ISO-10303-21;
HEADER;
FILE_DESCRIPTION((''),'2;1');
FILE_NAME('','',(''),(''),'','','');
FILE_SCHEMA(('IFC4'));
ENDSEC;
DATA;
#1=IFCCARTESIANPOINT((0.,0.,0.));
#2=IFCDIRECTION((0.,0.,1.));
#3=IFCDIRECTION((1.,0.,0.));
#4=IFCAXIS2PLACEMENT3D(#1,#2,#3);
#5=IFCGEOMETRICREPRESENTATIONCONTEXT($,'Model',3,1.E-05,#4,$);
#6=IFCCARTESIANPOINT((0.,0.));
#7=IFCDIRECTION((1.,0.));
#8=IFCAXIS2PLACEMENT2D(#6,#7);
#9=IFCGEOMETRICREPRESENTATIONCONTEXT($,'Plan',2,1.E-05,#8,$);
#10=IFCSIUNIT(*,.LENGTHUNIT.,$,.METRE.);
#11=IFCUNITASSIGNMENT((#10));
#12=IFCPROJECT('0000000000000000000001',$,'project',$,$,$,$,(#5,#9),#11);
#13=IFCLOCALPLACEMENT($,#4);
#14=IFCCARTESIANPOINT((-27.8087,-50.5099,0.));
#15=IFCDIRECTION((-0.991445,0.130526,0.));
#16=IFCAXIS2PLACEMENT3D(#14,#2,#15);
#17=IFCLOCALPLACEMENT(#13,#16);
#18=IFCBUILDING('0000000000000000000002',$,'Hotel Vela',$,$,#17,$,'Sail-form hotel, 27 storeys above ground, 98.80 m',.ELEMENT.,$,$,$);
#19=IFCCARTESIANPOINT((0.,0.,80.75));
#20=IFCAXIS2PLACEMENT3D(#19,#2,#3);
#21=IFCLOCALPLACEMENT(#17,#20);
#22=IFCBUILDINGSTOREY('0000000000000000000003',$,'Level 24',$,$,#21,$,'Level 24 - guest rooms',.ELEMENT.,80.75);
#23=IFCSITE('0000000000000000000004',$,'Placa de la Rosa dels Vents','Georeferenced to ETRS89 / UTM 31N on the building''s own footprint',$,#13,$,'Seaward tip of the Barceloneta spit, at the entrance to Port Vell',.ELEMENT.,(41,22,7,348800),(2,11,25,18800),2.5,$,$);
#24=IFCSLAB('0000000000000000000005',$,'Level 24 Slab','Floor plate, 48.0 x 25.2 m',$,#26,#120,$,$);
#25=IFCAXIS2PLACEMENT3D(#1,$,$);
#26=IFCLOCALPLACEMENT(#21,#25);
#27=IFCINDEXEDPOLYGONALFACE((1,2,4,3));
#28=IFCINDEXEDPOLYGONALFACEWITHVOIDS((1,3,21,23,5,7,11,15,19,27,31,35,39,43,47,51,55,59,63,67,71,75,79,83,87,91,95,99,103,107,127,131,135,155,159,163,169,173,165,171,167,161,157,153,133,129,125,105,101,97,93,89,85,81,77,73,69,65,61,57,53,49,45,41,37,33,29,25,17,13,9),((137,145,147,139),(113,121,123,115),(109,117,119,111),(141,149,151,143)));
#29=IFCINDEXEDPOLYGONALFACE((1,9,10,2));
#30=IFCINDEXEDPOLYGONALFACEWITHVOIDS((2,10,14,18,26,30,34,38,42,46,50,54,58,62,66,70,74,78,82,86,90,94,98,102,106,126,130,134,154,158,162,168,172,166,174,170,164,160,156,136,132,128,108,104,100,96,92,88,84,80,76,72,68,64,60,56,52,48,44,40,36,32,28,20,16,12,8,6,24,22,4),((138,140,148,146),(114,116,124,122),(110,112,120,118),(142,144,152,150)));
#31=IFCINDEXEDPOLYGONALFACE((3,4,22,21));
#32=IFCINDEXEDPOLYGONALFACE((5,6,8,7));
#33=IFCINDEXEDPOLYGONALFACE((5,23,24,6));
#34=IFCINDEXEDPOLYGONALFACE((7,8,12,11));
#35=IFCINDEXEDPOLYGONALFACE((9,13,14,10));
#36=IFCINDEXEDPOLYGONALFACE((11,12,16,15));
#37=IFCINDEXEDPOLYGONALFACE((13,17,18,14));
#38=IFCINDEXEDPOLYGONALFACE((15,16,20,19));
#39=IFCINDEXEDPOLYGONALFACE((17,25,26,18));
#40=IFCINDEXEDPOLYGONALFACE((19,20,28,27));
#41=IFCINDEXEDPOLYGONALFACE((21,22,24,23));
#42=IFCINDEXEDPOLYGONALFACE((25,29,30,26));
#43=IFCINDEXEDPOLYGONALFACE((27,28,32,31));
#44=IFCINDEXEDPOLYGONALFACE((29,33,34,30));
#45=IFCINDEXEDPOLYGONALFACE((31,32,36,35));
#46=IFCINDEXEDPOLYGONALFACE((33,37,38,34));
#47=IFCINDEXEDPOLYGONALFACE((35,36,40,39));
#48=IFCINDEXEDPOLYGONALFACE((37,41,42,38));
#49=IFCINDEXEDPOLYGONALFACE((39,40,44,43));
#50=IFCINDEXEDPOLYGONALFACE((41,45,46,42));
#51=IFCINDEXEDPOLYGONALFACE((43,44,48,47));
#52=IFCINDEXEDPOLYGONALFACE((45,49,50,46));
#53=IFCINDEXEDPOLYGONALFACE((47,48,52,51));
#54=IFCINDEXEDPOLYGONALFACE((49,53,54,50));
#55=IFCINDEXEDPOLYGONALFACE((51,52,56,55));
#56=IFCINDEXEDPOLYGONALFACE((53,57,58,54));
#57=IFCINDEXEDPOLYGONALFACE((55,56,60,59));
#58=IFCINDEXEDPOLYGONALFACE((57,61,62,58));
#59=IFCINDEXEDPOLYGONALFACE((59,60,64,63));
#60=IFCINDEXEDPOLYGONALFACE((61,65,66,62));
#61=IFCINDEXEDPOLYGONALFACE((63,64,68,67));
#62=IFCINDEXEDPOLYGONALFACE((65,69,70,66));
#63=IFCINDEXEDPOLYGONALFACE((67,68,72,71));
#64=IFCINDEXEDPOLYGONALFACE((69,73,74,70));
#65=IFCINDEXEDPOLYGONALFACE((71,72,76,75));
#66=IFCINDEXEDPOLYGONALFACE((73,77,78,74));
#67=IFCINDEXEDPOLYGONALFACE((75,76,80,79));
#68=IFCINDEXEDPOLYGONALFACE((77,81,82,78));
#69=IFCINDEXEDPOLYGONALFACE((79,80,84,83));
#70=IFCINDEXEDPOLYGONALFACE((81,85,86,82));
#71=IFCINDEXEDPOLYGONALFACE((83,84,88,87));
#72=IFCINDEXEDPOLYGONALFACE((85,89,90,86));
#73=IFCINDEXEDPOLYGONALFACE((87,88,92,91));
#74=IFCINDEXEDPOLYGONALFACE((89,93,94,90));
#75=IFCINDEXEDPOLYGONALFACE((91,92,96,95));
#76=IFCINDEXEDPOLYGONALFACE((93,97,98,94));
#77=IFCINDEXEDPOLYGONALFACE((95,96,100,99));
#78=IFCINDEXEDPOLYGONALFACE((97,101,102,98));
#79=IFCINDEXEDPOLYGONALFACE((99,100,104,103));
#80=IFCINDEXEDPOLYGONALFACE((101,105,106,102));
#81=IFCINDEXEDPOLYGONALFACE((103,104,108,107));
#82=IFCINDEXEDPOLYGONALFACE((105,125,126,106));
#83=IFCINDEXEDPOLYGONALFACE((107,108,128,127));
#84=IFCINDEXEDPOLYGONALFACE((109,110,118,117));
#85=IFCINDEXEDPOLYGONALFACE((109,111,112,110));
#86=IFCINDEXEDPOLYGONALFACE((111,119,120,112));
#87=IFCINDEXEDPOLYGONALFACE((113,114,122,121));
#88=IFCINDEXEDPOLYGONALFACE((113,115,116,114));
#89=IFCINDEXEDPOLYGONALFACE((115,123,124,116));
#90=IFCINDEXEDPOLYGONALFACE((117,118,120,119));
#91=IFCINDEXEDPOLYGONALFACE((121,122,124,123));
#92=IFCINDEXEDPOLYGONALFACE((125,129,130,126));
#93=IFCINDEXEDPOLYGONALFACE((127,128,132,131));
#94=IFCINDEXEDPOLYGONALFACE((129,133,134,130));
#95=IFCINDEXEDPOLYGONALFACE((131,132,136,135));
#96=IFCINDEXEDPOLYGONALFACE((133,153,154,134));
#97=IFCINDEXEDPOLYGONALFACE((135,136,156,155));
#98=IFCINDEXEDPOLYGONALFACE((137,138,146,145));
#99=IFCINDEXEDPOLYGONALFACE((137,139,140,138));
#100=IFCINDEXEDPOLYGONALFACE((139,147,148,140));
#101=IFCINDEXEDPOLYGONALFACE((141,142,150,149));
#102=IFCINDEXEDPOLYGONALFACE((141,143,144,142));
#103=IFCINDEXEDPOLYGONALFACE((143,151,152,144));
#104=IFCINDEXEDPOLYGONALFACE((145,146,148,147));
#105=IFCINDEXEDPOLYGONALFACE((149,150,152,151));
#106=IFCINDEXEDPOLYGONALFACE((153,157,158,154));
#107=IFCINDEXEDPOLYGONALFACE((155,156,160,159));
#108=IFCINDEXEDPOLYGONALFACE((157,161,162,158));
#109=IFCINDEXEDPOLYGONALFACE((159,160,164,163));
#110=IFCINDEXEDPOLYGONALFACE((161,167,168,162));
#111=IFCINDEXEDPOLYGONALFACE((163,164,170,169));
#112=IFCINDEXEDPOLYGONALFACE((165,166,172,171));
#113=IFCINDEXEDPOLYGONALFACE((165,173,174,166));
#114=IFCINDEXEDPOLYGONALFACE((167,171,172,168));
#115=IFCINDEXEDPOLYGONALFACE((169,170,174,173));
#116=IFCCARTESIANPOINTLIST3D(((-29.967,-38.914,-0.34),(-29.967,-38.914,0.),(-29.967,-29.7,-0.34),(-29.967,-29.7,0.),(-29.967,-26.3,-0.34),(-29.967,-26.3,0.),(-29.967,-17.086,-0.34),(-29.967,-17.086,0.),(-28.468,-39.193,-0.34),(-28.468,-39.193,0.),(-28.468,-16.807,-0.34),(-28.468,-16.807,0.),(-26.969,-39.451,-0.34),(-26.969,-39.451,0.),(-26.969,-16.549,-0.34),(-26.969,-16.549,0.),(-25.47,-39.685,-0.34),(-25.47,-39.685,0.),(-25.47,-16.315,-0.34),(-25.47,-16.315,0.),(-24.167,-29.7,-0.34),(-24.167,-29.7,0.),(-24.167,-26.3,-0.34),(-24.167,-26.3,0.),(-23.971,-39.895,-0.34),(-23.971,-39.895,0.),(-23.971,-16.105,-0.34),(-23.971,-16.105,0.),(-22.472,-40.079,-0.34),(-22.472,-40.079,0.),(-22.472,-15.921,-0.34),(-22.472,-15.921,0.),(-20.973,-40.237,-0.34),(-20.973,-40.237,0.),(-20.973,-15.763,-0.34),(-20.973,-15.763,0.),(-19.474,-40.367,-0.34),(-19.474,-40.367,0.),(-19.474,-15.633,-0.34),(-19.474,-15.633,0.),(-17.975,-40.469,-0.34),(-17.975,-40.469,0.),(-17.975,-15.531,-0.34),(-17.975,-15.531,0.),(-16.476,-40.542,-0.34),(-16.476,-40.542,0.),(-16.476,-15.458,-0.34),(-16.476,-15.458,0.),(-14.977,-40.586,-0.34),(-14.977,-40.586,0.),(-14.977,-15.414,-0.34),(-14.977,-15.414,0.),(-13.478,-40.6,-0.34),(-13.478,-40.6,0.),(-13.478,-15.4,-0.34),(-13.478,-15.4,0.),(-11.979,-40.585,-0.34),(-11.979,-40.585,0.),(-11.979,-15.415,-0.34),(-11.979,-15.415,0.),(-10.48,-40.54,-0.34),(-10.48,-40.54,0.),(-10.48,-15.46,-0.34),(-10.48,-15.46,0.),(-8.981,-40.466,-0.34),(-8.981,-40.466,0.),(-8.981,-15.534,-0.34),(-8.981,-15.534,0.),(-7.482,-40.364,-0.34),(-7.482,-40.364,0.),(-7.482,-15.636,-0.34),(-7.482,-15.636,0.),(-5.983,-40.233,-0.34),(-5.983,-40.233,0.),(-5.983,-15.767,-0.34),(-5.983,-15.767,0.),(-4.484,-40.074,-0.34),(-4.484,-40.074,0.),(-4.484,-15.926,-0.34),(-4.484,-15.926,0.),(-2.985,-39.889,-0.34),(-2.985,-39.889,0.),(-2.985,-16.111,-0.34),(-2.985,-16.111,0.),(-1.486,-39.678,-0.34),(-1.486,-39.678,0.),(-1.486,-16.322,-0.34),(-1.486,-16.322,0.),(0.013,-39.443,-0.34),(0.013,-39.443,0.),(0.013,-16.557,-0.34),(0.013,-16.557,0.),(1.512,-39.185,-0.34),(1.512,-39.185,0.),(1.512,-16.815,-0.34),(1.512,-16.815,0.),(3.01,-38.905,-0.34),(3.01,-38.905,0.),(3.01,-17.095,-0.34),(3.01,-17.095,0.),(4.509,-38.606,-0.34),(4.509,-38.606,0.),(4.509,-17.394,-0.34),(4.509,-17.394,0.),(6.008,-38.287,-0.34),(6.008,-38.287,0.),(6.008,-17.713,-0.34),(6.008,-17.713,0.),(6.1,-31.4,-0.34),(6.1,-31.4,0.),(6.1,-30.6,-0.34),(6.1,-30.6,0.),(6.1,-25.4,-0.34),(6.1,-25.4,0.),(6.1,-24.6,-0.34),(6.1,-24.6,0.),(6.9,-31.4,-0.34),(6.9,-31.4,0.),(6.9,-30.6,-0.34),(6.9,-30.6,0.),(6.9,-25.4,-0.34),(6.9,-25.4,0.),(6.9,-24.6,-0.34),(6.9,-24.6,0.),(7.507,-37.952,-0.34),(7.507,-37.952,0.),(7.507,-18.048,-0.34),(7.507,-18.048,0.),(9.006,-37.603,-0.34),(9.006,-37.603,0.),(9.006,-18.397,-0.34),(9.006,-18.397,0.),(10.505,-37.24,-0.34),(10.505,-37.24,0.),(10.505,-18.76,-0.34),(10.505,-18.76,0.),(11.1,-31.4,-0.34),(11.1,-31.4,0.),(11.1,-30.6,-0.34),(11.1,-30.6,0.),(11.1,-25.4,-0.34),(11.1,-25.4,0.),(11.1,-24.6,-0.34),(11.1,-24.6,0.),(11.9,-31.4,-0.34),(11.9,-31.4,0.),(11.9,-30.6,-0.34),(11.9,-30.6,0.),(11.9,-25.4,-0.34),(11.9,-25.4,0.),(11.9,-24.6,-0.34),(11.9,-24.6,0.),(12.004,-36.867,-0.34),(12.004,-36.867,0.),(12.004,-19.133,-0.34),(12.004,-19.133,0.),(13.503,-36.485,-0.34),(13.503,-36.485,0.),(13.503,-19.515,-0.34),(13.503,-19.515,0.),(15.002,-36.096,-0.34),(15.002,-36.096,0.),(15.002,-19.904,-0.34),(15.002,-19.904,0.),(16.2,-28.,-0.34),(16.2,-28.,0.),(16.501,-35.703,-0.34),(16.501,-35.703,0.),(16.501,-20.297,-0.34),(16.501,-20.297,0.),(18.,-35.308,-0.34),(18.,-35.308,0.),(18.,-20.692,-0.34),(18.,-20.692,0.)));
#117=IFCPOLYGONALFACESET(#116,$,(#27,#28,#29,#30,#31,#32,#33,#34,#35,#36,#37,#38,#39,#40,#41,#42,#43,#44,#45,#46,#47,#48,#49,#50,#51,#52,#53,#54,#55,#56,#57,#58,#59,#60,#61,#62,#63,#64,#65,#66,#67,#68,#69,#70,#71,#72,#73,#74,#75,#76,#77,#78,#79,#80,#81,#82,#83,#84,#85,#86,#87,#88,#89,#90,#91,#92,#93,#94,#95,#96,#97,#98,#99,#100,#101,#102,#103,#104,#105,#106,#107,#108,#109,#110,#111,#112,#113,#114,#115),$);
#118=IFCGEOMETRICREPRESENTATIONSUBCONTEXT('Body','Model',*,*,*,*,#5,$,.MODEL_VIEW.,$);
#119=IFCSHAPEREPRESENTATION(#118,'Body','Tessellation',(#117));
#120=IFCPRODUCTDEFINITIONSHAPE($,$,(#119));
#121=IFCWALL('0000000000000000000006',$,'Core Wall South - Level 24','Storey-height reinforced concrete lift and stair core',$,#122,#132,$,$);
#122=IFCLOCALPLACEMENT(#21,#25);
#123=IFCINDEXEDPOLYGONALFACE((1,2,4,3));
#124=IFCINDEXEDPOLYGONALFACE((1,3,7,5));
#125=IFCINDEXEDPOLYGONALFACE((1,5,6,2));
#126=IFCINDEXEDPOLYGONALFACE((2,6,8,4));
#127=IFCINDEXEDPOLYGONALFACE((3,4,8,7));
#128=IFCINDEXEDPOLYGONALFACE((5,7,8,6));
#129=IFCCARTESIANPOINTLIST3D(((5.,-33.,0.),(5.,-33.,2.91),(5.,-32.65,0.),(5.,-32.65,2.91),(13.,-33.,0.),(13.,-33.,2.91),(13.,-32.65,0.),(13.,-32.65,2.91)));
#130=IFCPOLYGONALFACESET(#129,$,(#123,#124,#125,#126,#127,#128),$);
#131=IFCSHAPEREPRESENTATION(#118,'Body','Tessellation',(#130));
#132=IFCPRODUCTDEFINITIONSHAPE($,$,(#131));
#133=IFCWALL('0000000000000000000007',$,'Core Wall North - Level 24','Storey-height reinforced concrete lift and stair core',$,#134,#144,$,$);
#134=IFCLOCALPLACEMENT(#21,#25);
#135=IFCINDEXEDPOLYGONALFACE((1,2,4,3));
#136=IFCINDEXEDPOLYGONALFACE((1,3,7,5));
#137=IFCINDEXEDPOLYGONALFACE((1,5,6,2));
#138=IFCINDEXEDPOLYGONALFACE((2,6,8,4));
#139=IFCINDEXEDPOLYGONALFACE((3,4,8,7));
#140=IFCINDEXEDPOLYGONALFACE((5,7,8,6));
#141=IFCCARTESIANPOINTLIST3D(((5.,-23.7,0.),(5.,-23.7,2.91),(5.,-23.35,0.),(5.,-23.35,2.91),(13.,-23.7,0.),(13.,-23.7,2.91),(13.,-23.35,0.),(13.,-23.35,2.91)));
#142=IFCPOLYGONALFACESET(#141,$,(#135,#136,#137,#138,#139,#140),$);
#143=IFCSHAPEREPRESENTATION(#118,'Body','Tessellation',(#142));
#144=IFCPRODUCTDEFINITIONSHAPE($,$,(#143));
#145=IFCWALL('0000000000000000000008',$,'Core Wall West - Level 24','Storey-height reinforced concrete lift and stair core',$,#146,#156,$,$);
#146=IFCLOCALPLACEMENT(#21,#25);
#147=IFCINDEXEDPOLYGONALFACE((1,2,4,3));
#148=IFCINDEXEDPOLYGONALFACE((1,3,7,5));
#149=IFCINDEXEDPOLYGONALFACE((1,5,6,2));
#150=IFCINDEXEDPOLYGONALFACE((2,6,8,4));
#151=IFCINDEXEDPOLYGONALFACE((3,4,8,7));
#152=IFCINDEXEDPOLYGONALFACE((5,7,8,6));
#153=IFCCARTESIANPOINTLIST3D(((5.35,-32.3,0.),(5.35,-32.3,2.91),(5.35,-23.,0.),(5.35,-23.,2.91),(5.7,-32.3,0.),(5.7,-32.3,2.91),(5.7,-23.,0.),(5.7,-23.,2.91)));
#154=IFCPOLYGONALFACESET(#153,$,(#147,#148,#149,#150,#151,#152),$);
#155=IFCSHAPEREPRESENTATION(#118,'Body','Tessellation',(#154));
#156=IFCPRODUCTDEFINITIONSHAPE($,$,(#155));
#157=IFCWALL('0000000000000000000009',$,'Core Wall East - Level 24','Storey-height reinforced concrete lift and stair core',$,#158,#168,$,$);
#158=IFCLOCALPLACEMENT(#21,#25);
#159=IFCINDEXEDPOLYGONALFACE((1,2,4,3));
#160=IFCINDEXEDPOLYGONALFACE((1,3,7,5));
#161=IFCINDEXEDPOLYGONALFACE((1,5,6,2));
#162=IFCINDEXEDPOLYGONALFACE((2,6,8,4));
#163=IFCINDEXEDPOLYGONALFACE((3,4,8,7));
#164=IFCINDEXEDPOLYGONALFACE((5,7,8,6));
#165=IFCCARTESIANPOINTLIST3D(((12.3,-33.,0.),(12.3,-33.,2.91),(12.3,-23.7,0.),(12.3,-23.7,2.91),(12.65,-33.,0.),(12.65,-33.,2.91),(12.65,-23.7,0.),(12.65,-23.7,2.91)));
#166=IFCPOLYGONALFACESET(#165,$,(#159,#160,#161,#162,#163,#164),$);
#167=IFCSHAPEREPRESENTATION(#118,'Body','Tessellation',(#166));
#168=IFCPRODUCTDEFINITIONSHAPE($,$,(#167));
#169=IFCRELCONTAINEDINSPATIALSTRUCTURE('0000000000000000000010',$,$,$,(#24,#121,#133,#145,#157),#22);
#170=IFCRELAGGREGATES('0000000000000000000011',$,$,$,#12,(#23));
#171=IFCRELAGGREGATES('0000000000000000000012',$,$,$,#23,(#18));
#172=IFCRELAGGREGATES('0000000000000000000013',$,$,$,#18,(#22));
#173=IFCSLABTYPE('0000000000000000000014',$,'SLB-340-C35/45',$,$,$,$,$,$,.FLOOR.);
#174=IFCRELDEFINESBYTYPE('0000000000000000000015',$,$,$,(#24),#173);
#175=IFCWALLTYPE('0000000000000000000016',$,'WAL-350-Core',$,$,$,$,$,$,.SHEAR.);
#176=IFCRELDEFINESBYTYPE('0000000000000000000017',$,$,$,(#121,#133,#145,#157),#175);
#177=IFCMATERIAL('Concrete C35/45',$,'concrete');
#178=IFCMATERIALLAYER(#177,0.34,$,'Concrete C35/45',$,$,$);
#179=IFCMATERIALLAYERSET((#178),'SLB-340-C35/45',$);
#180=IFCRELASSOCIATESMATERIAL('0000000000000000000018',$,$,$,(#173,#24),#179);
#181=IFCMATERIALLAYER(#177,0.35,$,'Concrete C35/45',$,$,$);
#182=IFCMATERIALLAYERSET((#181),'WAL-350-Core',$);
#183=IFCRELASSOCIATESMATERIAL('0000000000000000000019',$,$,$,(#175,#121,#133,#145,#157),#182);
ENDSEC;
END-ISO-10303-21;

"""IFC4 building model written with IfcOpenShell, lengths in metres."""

from ifc_helpers import new_model, si_unit, frame, origin_with_axes, origin_2d_with_axis, place, context, subcontext, project, spatial, line, indexed_curve, outline, extrude, material, layer, layer_set, layer_usage, type_object, element, save


model = new_model("IFC4")

# Units and contexts
model_context = context("Model", 3, precision=1e-05, world=origin_with_axes())
plan_context = context("Plan", 2, precision=1e-05, world=origin_2d_with_axis())
body_context = subcontext(model_context, "Body", "Model", "MODEL_VIEW")
ifc_project = project(units=[si_unit("LENGTHUNIT", "METRE")], contexts=[model_context, plan_context])

# Site, building, storey
site_placement = place(None, origin_with_axes())
site = spatial("IfcSite", under=ifc_project, at=site_placement, Name="Placa de la Rosa dels Vents", Description="Georeferenced to ETRS89 / UTM 31N on the building's own footprint", LongName="Seaward tip of the Barceloneta spit, at the entrance to Port Vell", CompositionType="ELEMENT", RefLatitude=(41, 22, 7, 348800), RefLongitude=(2, 11, 25, 18800), RefElevation=2.5)
building_placement = place(site_placement, frame((-27.8087, -50.5099, 0.0), z_axis=(0.0, 0.0, 1.0), x_axis=(-0.991445, 0.130526, 0.0)))
building = spatial("IfcBuilding", under=site, at=building_placement, Name="Hotel Vela", LongName="Sail-form hotel, 27 storeys above ground, 98.80 m", CompositionType="ELEMENT")
storey_placement = place(building_placement, frame((0.0, 0.0, 80.75), z_axis=(0.0, 0.0, 1.0), x_axis=(1.0, 0.0, 0.0)))
storey = spatial("IfcBuildingStorey", under=building, at=storey_placement, Name="Level 24", LongName="Level 24 - guest rooms", CompositionType="ELEMENT", Elevation=80.75)

# Shared definitions
ifc_material = material(Name="Concrete C35/45", Category="concrete")

# Slab, openings
ifc_layer_1 = layer(ifc_material, 0.34, Name="Concrete C35/45")
ifc_layer_set_1 = layer_set([ifc_layer_1], Name="SLB-340-C35/45")
ifc_layer_usage_1 = layer_usage(ifc_layer_set_1, "AXIS3", "POSITIVE", 0.0)
slab_type = type_object("IfcSlabType", Name="SLB-340-C35/45", PredefinedType="FLOOR", material=ifc_layer_set_1)
slab_placement = place(storey_placement, frame((0.0, 0.0, -0.34), z_axis=(0.0, 0.0, 1.0), x_axis=(1.0, 0.0, 0.0)))
slab = element("IfcSlab", 1, at=slab_placement, inside=storey, type_object=slab_type, material=ifc_layer_usage_1, Name="Level 24 Slab", Description="Floor plate, 48.0 x 25.2 m", context=body_context, shape_type="SweptSolid", body=[
    extrude(outline(indexed_curve([(-29.967, -38.914), (-28.468, -39.193), (-26.969, -39.451), (-25.47, -39.685), (-23.971, -39.895), (-22.472, -40.079), (-20.973, -40.237), (-19.474, -40.367), (-17.975, -40.469), (-16.476, -40.542), (-14.977, -40.586), (-13.478, -40.6), (-11.979, -40.585), (-10.48, -40.54), (-8.981, -40.466), (-7.482, -40.364), (-5.983, -40.233), (-4.484, -40.074), (-2.985, -39.889), (-1.486, -39.678), (0.013, -39.443), (1.512, -39.185), (3.01, -38.905), (4.509, -38.606), (6.008, -38.287), (7.507, -37.952), (9.006, -37.603), (10.505, -37.24), (12.004, -36.867), (13.503, -36.485), (15.002, -36.096), (16.501, -35.703), (18.0, -35.308), (16.2, -28.0), (18.0, -20.692), (16.501, -20.297), (15.002, -19.904), (13.503, -19.515), (12.004, -19.133), (10.505, -18.76), (9.006, -18.397), (7.507, -18.048), (6.008, -17.713), (4.509, -17.394), (3.01, -17.095), (1.512, -16.815), (0.013, -16.557), (-1.486, -16.322), (-2.985, -16.111), (-4.484, -15.926), (-5.983, -15.767), (-7.482, -15.636), (-8.981, -15.534), (-10.48, -15.46), (-11.979, -15.415), (-13.478, -15.4), (-14.977, -15.414), (-16.476, -15.458), (-17.975, -15.531), (-19.474, -15.633), (-20.973, -15.763), (-22.472, -15.921), (-23.971, -16.105), (-25.47, -16.315), (-26.969, -16.549), (-28.468, -16.807), (-29.967, -17.086), (-29.967, -26.3), (-24.167, -26.3), (-24.167, -29.7), (-29.967, -29.7)], segments=[line(1, 2, 3, 4, 5, 6, 7, 8, 9, 10, 11, 12, 13, 14, 15, 16, 17, 18, 19, 20, 21, 22, 23, 24, 25, 26, 27, 28, 29, 30, 31, 32, 33, 34, 35, 36, 37, 38, 39, 40, 41, 42, 43, 44, 45, 46, 47, 48, 49, 50, 51, 52, 53, 54, 55, 56, 57, 58, 59, 60, 61, 62, 63, 64, 65, 66, 67, 68, 69, 70, 71, 1)])), origin_with_axes(), (0.0, 0.0, 1.0), 0.34),
])
opening_1_placement = place(slab_placement, frame((6.1, -31.4, -0.05), z_axis=(0.0, 0.0, 1.0), x_axis=(1.0, 0.0, 0.0)))
element("IfcOpeningElement", 2, at=opening_1_placement, cuts=slab, PredefinedType="OPENING", context=body_context, shape_type="SweptSolid", body=[
    extrude(outline(indexed_curve([(0.0, 0.0), (0.8, 0.0), (0.8, 0.8), (0.0, 0.8)], segments=[line(1, 2, 3, 4, 1)])), origin_with_axes(), (0.0, 0.0, 1.0), 0.44),
])
opening_2_placement = place(slab_placement, frame((6.1, -25.4, -0.05), z_axis=(0.0, 0.0, 1.0), x_axis=(1.0, 0.0, 0.0)))
element("IfcOpeningElement", 3, at=opening_2_placement, cuts=slab, PredefinedType="OPENING", context=body_context, shape_type="SweptSolid", body=[
    extrude(outline(indexed_curve([(0.0, 0.0), (0.8, 0.0), (0.8, 0.8), (0.0, 0.8)], segments=[line(1, 2, 3, 4, 1)])), origin_with_axes(), (0.0, 0.0, 1.0), 0.44),
])
opening_3_placement = place(slab_placement, frame((11.1, -31.4, -0.05), z_axis=(0.0, 0.0, 1.0), x_axis=(1.0, 0.0, 0.0)))
element("IfcOpeningElement", 4, at=opening_3_placement, cuts=slab, PredefinedType="OPENING", context=body_context, shape_type="SweptSolid", body=[
    extrude(outline(indexed_curve([(0.0, 0.0), (0.8, 0.0), (0.8, 0.8), (0.0, 0.8)], segments=[line(1, 2, 3, 4, 1)])), origin_with_axes(), (0.0, 0.0, 1.0), 0.44),
])
opening_4_placement = place(slab_placement, frame((11.1, -25.4, -0.05), z_axis=(0.0, 0.0, 1.0), x_axis=(1.0, 0.0, 0.0)))
element("IfcOpeningElement", 5, at=opening_4_placement, cuts=slab, PredefinedType="OPENING", context=body_context, shape_type="SweptSolid", body=[
    extrude(outline(indexed_curve([(0.0, 0.0), (0.8, 0.0), (0.8, 0.8), (0.0, 0.8)], segments=[line(1, 2, 3, 4, 1)])), origin_with_axes(), (0.0, 0.0, 1.0), 0.44),
])

# Walls
ifc_layer_2 = layer(ifc_material, 0.35, Name="Concrete C35/45")
ifc_layer_set_2 = layer_set([ifc_layer_2], Name="WAL-350-Core")
ifc_layer_usage_2 = layer_usage(ifc_layer_set_2, "AXIS2", "POSITIVE", 0.0)
wall_type = type_object("IfcWallType", Name="WAL-350-Core", PredefinedType="SHEAR", material=ifc_layer_set_2)
wall_1_placement = place(storey_placement, frame((5.0, -33.0, 0.0), z_axis=(0.0, 0.0, 1.0), x_axis=(1.0, 0.0, 0.0)))
element("IfcWall", 6, at=wall_1_placement, inside=storey, type_object=wall_type, material=ifc_layer_usage_2, Name="Core Wall South - Level 24", Description="Storey-height reinforced concrete lift and stair core", context=body_context, shape_type="SweptSolid", body=[
    extrude(outline(indexed_curve([(0.0, 0.0), (8.0, 0.0), (8.0, 0.35), (0.0, 0.35)], segments=[line(1, 2, 3, 4, 1)])), origin_with_axes(), (0.0, 0.0, 1.0), 2.91),
])
ifc_layer_usage_3 = layer_usage(ifc_layer_set_2, "AXIS2", "POSITIVE", 0.0)
wall_2_placement = place(storey_placement, frame((13.0, -23.35, 0.0), z_axis=(0.0, 0.0, 1.0), x_axis=(-1.0, 0.0, 0.0)))
element("IfcWall", 7, at=wall_2_placement, inside=storey, type_object=wall_type, material=ifc_layer_usage_3, Name="Core Wall North - Level 24", Description="Storey-height reinforced concrete lift and stair core", context=body_context, shape_type="SweptSolid", body=[
    extrude(outline(indexed_curve([(0.0, 0.0), (8.0, 0.0), (8.0, 0.35), (0.0, 0.35)], segments=[line(1, 2, 3, 4, 1)])), origin_with_axes(), (0.0, 0.0, 1.0), 2.91),
])
ifc_layer_usage_4 = layer_usage(ifc_layer_set_2, "AXIS2", "POSITIVE", 0.0)
wall_3_placement = place(storey_placement, frame((5.35, -23.0, 0.0), z_axis=(0.0, 0.0, 1.0), x_axis=(0.0, -1.0, 0.0)))
element("IfcWall", 8, at=wall_3_placement, inside=storey, type_object=wall_type, material=ifc_layer_usage_4, Name="Core Wall West - Level 24", Description="Storey-height reinforced concrete lift and stair core", context=body_context, shape_type="SweptSolid", body=[
    extrude(outline(indexed_curve([(0.0, 0.0), (9.3, 0.0), (9.3, 0.35), (0.0, 0.35)], segments=[line(1, 2, 3, 4, 1)])), origin_with_axes(), (0.0, 0.0, 1.0), 2.91),
])
ifc_layer_usage_5 = layer_usage(ifc_layer_set_2, "AXIS2", "POSITIVE", 0.0)
wall_4_placement = place(storey_placement, frame((12.65, -33.0, 0.0), z_axis=(0.0, 0.0, 1.0), x_axis=(0.0, 1.0, 0.0)))
element("IfcWall", 9, at=wall_4_placement, inside=storey, type_object=wall_type, material=ifc_layer_usage_5, Name="Core Wall East - Level 24", Description="Storey-height reinforced concrete lift and stair core", context=body_context, shape_type="SweptSolid", body=[
    extrude(outline(indexed_curve([(0.0, 0.0), (9.3, 0.0), (9.3, 0.35), (0.0, 0.35)], segments=[line(1, 2, 3, 4, 1)])), origin_with_axes(), (0.0, 0.0, 1.0), 2.91),
])

save(model, "model.ifc")
